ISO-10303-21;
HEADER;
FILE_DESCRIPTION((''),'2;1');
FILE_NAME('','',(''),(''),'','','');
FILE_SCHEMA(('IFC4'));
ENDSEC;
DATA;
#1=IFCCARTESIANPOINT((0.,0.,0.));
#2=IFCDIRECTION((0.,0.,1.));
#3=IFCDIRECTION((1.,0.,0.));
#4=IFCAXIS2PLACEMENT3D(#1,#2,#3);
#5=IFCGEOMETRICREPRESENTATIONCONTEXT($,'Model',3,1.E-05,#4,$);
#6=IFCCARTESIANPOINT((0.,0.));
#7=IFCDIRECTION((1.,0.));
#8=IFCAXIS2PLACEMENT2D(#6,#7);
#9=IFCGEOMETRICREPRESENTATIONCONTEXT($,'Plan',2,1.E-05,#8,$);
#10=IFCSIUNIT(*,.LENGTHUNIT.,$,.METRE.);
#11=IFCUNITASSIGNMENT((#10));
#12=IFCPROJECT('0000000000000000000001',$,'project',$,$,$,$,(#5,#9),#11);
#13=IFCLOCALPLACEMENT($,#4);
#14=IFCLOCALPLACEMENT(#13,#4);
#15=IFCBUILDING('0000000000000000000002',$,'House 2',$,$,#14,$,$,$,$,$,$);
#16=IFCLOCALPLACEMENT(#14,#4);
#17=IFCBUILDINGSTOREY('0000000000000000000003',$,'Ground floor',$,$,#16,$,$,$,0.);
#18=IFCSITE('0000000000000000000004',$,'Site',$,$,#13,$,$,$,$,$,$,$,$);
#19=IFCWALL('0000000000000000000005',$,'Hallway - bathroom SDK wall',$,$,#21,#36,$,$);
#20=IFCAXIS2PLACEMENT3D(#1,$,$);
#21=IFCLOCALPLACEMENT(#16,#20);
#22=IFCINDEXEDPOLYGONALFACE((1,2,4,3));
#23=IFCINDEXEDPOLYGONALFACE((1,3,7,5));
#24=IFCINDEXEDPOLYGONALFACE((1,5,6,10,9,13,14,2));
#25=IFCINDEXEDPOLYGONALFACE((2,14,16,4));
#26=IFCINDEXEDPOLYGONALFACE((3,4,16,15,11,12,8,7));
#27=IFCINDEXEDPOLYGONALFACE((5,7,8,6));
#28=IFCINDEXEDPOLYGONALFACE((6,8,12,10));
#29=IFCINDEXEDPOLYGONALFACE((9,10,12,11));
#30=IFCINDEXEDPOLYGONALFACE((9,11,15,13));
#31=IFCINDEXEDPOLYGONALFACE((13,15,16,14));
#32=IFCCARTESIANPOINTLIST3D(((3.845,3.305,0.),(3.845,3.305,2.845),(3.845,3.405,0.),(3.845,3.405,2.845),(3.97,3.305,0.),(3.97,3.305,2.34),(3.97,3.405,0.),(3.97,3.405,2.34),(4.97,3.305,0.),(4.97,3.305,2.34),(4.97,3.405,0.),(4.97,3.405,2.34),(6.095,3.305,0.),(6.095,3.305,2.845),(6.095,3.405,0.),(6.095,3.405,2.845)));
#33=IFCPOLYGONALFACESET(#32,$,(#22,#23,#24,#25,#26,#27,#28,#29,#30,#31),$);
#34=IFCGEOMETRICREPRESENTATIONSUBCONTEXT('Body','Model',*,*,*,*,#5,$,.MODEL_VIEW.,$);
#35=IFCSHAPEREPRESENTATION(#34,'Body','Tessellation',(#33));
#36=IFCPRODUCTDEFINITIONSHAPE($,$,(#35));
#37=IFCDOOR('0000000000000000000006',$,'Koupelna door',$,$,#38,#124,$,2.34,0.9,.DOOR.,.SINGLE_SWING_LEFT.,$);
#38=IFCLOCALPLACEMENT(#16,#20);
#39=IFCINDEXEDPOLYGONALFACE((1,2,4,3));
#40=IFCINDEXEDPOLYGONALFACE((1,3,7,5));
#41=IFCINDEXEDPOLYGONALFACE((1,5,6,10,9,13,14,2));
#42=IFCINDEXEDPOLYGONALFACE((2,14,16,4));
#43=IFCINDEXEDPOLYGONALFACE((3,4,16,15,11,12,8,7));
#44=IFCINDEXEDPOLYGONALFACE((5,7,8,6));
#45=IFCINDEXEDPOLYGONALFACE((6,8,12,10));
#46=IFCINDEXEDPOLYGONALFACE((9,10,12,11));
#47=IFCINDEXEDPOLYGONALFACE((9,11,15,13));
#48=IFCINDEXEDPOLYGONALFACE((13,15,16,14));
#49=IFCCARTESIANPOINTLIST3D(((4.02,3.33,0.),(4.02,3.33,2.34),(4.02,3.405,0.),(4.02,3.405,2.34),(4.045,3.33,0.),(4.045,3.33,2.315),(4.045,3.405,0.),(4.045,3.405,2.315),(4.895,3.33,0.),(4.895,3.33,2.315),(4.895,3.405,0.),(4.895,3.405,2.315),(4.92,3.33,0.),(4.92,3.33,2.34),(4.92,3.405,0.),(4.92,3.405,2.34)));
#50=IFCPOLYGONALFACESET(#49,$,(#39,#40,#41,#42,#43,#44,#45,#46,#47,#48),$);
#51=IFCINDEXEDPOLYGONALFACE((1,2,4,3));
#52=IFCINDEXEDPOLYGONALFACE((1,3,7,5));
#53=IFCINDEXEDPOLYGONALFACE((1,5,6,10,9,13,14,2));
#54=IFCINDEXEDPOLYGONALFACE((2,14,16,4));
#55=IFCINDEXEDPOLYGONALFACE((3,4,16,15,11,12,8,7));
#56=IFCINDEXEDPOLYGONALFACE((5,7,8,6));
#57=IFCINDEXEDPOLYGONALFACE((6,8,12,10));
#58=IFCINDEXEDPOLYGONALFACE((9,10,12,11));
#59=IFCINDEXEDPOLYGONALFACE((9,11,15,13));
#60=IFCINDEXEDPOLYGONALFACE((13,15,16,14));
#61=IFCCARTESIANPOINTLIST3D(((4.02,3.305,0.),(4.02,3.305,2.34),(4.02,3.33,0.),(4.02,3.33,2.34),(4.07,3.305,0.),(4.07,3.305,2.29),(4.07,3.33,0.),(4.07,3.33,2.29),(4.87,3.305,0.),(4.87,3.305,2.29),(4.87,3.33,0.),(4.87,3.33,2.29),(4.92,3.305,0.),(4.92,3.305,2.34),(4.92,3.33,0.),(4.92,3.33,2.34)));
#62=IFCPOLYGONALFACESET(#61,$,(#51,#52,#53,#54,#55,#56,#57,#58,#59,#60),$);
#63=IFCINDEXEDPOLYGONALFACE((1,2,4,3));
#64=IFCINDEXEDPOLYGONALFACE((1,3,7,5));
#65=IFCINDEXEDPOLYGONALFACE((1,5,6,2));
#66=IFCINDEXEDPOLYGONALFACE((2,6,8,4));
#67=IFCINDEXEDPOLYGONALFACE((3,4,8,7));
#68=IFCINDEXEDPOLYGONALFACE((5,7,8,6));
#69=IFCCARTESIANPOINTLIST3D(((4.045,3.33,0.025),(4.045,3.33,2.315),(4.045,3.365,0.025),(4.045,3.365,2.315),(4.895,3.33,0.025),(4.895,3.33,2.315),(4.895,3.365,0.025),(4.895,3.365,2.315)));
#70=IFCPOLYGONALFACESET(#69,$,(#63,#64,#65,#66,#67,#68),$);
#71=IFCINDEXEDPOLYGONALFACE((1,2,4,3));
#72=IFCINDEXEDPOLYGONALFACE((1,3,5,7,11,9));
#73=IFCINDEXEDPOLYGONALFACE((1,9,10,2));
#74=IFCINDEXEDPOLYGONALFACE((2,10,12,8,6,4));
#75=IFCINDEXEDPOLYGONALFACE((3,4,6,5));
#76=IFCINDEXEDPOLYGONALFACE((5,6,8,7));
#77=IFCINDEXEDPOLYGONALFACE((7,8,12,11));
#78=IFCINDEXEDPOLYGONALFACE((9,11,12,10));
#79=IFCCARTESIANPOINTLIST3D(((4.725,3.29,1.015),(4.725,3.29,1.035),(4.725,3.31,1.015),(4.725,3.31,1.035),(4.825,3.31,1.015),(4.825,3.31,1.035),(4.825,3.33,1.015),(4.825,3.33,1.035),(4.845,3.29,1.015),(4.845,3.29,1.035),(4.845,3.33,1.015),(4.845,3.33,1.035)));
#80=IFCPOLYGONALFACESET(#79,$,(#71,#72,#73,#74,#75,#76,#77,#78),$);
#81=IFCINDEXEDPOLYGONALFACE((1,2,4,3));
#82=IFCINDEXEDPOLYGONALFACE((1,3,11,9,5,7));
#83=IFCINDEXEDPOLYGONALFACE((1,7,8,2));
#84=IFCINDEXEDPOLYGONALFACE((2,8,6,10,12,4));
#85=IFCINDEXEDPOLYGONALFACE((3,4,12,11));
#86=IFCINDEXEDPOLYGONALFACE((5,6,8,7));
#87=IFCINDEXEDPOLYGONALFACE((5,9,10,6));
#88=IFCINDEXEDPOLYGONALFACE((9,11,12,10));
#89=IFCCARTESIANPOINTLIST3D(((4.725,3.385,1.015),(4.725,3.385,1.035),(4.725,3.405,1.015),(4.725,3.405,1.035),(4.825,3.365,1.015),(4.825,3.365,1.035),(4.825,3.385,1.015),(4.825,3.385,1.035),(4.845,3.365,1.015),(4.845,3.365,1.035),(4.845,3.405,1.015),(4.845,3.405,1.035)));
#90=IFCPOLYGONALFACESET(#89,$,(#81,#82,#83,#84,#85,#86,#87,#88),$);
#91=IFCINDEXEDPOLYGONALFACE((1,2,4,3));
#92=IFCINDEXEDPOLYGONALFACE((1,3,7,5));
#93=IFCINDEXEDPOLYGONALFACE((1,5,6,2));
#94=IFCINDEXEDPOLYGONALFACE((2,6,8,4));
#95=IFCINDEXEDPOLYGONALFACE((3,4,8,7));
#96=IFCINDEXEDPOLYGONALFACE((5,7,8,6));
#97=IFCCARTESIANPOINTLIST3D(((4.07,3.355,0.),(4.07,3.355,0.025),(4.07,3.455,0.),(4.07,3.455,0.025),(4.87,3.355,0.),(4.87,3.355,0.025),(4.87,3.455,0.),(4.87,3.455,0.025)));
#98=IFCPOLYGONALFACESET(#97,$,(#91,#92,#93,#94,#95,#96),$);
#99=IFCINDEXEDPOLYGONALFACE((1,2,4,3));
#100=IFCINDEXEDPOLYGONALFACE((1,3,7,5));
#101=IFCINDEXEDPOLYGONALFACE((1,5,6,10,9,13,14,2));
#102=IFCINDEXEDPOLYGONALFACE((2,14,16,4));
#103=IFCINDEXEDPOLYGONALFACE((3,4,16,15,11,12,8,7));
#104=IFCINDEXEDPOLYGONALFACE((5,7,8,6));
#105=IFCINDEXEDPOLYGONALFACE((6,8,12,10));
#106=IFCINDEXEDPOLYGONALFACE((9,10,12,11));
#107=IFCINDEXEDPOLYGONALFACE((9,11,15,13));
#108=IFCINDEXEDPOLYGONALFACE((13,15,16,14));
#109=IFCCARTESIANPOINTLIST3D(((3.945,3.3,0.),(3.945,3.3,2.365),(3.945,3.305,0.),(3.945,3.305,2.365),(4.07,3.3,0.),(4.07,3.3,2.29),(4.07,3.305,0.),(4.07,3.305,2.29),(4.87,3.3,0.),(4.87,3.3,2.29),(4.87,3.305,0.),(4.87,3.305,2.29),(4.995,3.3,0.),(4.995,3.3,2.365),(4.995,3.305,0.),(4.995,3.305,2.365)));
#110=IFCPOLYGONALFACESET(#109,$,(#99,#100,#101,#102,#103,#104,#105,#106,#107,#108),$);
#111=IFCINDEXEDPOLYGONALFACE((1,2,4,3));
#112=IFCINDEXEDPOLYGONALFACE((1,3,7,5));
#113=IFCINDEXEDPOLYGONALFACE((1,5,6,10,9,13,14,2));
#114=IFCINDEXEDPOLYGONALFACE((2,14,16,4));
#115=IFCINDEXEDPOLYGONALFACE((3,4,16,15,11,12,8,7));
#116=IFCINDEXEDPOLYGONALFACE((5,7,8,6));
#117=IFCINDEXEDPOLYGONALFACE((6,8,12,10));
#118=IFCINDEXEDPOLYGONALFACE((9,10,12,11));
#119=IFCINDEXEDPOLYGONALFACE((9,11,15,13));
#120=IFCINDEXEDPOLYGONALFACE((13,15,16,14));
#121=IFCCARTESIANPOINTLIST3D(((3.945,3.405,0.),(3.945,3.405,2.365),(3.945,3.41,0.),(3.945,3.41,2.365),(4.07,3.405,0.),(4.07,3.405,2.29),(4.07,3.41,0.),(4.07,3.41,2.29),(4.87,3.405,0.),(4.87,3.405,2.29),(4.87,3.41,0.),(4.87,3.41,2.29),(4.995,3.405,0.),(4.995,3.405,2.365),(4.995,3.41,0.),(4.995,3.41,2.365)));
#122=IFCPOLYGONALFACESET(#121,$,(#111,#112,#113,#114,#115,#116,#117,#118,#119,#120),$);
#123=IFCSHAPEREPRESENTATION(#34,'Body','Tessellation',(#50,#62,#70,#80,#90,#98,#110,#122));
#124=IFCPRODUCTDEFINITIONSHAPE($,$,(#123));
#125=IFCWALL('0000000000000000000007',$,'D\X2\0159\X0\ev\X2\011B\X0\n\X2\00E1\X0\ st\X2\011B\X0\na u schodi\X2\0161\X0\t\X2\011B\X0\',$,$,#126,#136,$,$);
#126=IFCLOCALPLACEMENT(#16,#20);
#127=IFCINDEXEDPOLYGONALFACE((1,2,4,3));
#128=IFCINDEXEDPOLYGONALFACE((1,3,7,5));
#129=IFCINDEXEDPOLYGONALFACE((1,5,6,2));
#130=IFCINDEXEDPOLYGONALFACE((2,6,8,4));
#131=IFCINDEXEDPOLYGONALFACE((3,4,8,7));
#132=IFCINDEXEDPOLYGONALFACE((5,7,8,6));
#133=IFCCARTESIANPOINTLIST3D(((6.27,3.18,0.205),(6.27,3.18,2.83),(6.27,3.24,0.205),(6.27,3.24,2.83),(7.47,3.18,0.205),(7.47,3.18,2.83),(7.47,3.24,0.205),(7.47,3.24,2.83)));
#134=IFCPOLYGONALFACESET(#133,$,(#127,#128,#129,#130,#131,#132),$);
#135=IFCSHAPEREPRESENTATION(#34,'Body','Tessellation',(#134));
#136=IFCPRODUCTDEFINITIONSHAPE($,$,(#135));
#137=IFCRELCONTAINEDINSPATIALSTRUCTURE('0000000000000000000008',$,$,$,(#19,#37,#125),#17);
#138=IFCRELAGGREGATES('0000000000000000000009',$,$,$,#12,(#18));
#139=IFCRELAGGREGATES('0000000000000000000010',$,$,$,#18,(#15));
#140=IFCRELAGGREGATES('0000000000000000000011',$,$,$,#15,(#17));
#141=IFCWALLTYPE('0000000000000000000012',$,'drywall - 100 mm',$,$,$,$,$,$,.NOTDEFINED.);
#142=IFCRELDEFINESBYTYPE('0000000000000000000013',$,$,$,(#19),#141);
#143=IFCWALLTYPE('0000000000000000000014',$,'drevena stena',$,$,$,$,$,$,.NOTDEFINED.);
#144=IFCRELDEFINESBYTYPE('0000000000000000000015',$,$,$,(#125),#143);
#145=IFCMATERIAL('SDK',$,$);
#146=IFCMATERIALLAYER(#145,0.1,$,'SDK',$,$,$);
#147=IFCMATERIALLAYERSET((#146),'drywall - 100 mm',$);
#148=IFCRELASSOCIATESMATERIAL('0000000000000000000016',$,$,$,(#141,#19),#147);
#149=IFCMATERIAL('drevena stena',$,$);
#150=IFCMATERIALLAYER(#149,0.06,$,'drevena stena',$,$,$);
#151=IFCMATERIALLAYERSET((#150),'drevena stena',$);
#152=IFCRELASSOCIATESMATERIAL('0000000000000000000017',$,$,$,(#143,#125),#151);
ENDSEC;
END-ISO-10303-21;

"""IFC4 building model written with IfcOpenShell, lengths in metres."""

from ifc_helpers import new_model, entity, si_unit, frame, origin_with_axes, origin_2d_with_axis, place, context, subcontext, project, spatial, line, indexed_curve, outline, extrude, shape, source, transform, mapped, material, layer, layer_set, layer_usage, type_object, element, fill, save


model = new_model("IFC4")

# Units and contexts
model_context = context("Model", 3, precision=1e-05, world=origin_with_axes())
plan_context = context("Plan", 2, precision=1e-05, world=origin_2d_with_axis())
body_context_1 = subcontext(model_context, "Body", "Model", "MODEL_VIEW")
body_context_2 = subcontext(plan_context, "Body", "Plan", "PLAN_VIEW")
ifc_project = project(units=[si_unit("LENGTHUNIT", "METRE")], contexts=[model_context, plan_context])

# Site, building, storey
site_placement = place(None, origin_with_axes())
site = spatial("IfcSite", under=ifc_project, at=site_placement, Name="Site")
building_placement = place(site_placement, origin_with_axes())
building = spatial("IfcBuilding", under=site, at=building_placement, Name="House 2")
storey_placement = place(building_placement, origin_with_axes())
storey = spatial("IfcBuildingStorey", under=building, at=storey_placement, Name="Ground floor", Elevation=0.0)

# Shared definitions
ifc_material_1 = material(Name="SDK")
ifc_layer_1 = layer(ifc_material_1, 0.1, Name="SDK")
ifc_layer_set_1 = layer_set([ifc_layer_1], Name="drywall - 100 mm")
wall_type_1 = type_object("IfcWallType", Name="drywall - 100 mm", PredefinedType="NOTDEFINED", material=ifc_layer_set_1)

# Wall, opening, door
ifc_layer_usage_1 = layer_usage(ifc_layer_set_1, "AXIS2", "NEGATIVE", 0.05)
wall_1_placement = place(storey_placement, frame((3.845, 3.355, 0.0), z_axis=(0.0, 0.0, 1.0), x_axis=(1.0, 0.0, 0.0)))
wall_1 = element("IfcWall", 1, at=wall_1_placement, inside=storey, type_object=wall_type_1, material=ifc_layer_usage_1, Name="Hallway - bathroom SDK wall", context=body_context_1, shape_type="SweptSolid", body=[
    extrude(outline(indexed_curve([(0.0, 0.0), (0.0, 0.1), (2.25, 0.1), (2.25, 0.0), (0.0, 0.0)], self_intersect=False)), frame((0.0, -0.05, 0.0), z_axis=(0.0, 0.0, 1.0), x_axis=(1.0, 0.0, 0.0)), (0.0, 0.0, 1.0), 2.845),
])
opening_1_placement = place(wall_1_placement, frame((0.125, 0.0, 0.0), z_axis=(0.0, 0.0, 1.0), x_axis=(1.0, 0.0, 0.0)))
opening_1 = element("IfcOpeningElement", 2, at=opening_1_placement, cuts=wall_1, PredefinedType="OPENING", context=body_context_1, shape_type="SweptSolid", body=[
    extrude(outline(indexed_curve([(0.0, 0.0), (0.0, 0.2), (1.0, 0.2), (1.0, 0.0), (0.0, 0.0)], self_intersect=False)), frame((0.0, -0.1, 0.0), z_axis=(0.0, 0.0, 1.0), x_axis=(1.0, 0.0, 0.0)), (0.0, 0.0, 1.0), 2.34),
])
shared_indexed_poly_curve_1 = entity("IfcIndexedPolyCurve", entity("IfcCartesianPointList2D", [[-0.075, 0.0], [-0.075, 2.365], [0.975, 2.365], [0.975, 0.0], [0.85, 0.0], [0.85, 2.29], [0.05, 2.29], [0.05, 0.0]]), [entity("IfcLineIndex", [1, 2, 3, 4, 5, 6, 7, 8, 1])])
shared_shape_1 = source(origin_with_axes(), body_context_2, "Body", "Curve2D", [
    entity("IfcIndexedPolyCurve", entity("IfcCartesianPointList2D", [[0.0, -0.05], [0.0, 0.05], [0.025, 0.05], [0.025, -0.025], [0.05, -0.025], [0.05, -0.05]]), [entity("IfcLineIndex", [1, 2, 3, 4, 5, 6, 1])]),
    entity("IfcIndexedPolyCurve", entity("IfcCartesianPointList2D", [[0.9, -0.05], [0.9, 0.05], [0.875, 0.05], [0.875, -0.025], [0.85, -0.025], [0.85, -0.05]]), [entity("IfcLineIndex", [1, 2, 3, 4, 5, 6, 1])]),
    entity("IfcTrimmedCurve", entity("IfcEllipse", entity("IfcAxis2Placement2D", entity("IfcCartesianPoint", [0.06, -0.05]), entity("IfcDirection", [1.0, 0.0])), 0.815, 0.85), [entity("IfcCartesianPoint", [0.06, -0.9])], [entity("IfcCartesianPoint", [0.875, -0.05])], True, "CARTESIAN"),
    entity("IfcIndexedPolyCurve", entity("IfcCartesianPointList2D", [[0.025, -0.05], [0.06, -0.05], [0.06, -0.9], [0.025, -0.9]]), [entity("IfcLineIndex", [1, 2, 3, 4, 1])]),
])
door_1_placement = place(opening_1_placement, frame((0.05, 0.0, 0.0), z_axis=(0.0, 0.0, 1.0), x_axis=(1.0, 0.0, 0.0)))
door_1 = element("IfcDoor", 3, at=door_1_placement, inside=storey, Name="Koupelna door", OperationType="SINGLE_SWING_LEFT", OverallHeight=2.34, OverallWidth=0.9, PredefinedType="DOOR", shapes=[
    shape(body_context_1, "Body", "SweptSolid", [extrude(outline(indexed_curve([(0.0, 0.0), (0.0, 2.34), (0.9, 2.34), (0.9, 0.0), (0.875, 0.0), (0.875, 2.315), (0.025, 2.315), (0.025, 0.0)], segments=[line(1, 2, 3, 4, 5, 6, 7, 8, 1)])), frame((0.0, -0.025, 0.0), z_axis=(0.0, -1.0, 0.0), x_axis=(1.0, 0.0, 0.0)), (0.0, 0.0, -1.0), 0.075), extrude(outline(indexed_curve([(0.0, 0.0), (0.0, 2.34), (0.9, 2.34), (0.9, 0.0), (0.85, 0.0), (0.85, 2.29), (0.05, 2.29), (0.05, 0.0)], segments=[line(1, 2, 3, 4, 5, 6, 7, 8, 1)])), frame((0.0, -0.05, 0.0), z_axis=(0.0, -1.0, 0.0), x_axis=(1.0, 0.0, 0.0)), (0.0, 0.0, -1.0), 0.025), extrude(outline(indexed_curve([(0.0, 0.0), (0.85, 0.0), (0.85, 0.035), (0.0, 0.035)], segments=[line(1, 2, 3, 4, 1)])), frame((0.025, -0.025, 0.025), z_axis=(0.0, 0.0, 1.0), x_axis=(1.0, 0.0, 0.0)), (0.0, 0.0, 1.0), 2.29), extrude(outline(indexed_curve([(0.0, 0.0), (0.0, -0.04), (-0.12, -0.04), (-0.12, -0.02), (-0.02, -0.02), (-0.02, 0.0)], segments=[line(1, 2, 3, 4, 5, 6, 1)])), frame((0.825, -0.025, 1.015), z_axis=(0.0, 0.0, 1.0), x_axis=(1.0, 0.0, 0.0)), (0.0, 0.0, 1.0), 0.02), extrude(outline(indexed_curve([(0.0, 0.0), (0.0, 0.04), (-0.12, 0.04), (-0.12, 0.02), (-0.02, 0.02), (-0.02, 0.0)], segments=[line(1, 2, 3, 4, 5, 6, 1)])), frame((0.825, 0.01, 1.015), z_axis=(0.0, 0.0, 1.0), x_axis=(1.0, 0.0, 0.0)), (0.0, 0.0, 1.0), 0.02), extrude(outline(indexed_curve([(0.0, 0.0), (0.8, 0.0), (0.8, 0.1), (0.0, 0.1)], segments=[line(1, 2, 3, 4, 1)])), frame((0.05, 0.0, 0.0), z_axis=(0.0, 0.0, 1.0), x_axis=(1.0, 0.0, 0.0)), (0.0, 0.0, 1.0), 0.025), entity("IfcExtrudedAreaSolid", entity("IfcArbitraryClosedProfileDef", "AREA", None, shared_indexed_poly_curve_1), entity("IfcAxis2Placement3D", entity("IfcCartesianPoint", [0.0, -0.055, 0.0]), entity("IfcDirection", [0.0, -1.0, 0.0]), entity("IfcDirection", [1.0, 0.0, 0.0])), entity("IfcDirection", [0.0, 0.0, -1.0]), 0.005), entity("IfcExtrudedAreaSolid", entity("IfcArbitraryClosedProfileDef", "AREA", None, shared_indexed_poly_curve_1), entity("IfcAxis2Placement3D", entity("IfcCartesianPoint", [0.0, 0.05, 0.0]), entity("IfcDirection", [0.0, -1.0, 0.0]), entity("IfcDirection", [1.0, 0.0, 0.0])), entity("IfcDirection", [0.0, 0.0, -1.0]), 0.005)]),
    shape(body_context_2, "Body", "MappedRepresentation", [mapped(shared_shape_1, transform((0.0, 0.0, 1.17), x_axis=(1.0, 0.0, 0.0), y_axis=(0.0, 1.0, 0.0), z_axis=(0.0, 0.0, 1.0), scale=1.0))]),
])
fill(opening_1, door_1)

# Wall
ifc_material_2 = material(Name="drevena stena")
ifc_layer_2 = layer(ifc_material_2, 0.06, Name="drevena stena")
ifc_layer_set_2 = layer_set([ifc_layer_2], Name="drevena stena")
ifc_layer_usage_2 = layer_usage(ifc_layer_set_2, "AXIS2", "NEGATIVE", 0.03)
wall_type_2 = type_object("IfcWallType", Name="drevena stena", PredefinedType="NOTDEFINED", material=ifc_layer_set_2)
wall_2_placement = place(storey_placement, frame((6.27, 3.21, 0.205), z_axis=(0.0, 0.0, 1.0), x_axis=(1.0, 0.0, 0.0)))
element("IfcWall", 4, at=wall_2_placement, inside=storey, type_object=wall_type_2, material=ifc_layer_usage_2, Name="Dřevěná stěna u schodiště", context=body_context_1, shape_type="SweptSolid", body=[
    extrude(outline(indexed_curve([(0.0, 0.0), (0.0, 0.06), (1.2, 0.06), (1.2, 0.0), (0.0, 0.0)], self_intersect=False)), frame((0.0, -0.03, 0.0), z_axis=(0.0, 0.0, 1.0), x_axis=(1.0, 0.0, 0.0)), (0.0, 0.0, 1.0), 2.625),
])

save(model, "model.ifc")
